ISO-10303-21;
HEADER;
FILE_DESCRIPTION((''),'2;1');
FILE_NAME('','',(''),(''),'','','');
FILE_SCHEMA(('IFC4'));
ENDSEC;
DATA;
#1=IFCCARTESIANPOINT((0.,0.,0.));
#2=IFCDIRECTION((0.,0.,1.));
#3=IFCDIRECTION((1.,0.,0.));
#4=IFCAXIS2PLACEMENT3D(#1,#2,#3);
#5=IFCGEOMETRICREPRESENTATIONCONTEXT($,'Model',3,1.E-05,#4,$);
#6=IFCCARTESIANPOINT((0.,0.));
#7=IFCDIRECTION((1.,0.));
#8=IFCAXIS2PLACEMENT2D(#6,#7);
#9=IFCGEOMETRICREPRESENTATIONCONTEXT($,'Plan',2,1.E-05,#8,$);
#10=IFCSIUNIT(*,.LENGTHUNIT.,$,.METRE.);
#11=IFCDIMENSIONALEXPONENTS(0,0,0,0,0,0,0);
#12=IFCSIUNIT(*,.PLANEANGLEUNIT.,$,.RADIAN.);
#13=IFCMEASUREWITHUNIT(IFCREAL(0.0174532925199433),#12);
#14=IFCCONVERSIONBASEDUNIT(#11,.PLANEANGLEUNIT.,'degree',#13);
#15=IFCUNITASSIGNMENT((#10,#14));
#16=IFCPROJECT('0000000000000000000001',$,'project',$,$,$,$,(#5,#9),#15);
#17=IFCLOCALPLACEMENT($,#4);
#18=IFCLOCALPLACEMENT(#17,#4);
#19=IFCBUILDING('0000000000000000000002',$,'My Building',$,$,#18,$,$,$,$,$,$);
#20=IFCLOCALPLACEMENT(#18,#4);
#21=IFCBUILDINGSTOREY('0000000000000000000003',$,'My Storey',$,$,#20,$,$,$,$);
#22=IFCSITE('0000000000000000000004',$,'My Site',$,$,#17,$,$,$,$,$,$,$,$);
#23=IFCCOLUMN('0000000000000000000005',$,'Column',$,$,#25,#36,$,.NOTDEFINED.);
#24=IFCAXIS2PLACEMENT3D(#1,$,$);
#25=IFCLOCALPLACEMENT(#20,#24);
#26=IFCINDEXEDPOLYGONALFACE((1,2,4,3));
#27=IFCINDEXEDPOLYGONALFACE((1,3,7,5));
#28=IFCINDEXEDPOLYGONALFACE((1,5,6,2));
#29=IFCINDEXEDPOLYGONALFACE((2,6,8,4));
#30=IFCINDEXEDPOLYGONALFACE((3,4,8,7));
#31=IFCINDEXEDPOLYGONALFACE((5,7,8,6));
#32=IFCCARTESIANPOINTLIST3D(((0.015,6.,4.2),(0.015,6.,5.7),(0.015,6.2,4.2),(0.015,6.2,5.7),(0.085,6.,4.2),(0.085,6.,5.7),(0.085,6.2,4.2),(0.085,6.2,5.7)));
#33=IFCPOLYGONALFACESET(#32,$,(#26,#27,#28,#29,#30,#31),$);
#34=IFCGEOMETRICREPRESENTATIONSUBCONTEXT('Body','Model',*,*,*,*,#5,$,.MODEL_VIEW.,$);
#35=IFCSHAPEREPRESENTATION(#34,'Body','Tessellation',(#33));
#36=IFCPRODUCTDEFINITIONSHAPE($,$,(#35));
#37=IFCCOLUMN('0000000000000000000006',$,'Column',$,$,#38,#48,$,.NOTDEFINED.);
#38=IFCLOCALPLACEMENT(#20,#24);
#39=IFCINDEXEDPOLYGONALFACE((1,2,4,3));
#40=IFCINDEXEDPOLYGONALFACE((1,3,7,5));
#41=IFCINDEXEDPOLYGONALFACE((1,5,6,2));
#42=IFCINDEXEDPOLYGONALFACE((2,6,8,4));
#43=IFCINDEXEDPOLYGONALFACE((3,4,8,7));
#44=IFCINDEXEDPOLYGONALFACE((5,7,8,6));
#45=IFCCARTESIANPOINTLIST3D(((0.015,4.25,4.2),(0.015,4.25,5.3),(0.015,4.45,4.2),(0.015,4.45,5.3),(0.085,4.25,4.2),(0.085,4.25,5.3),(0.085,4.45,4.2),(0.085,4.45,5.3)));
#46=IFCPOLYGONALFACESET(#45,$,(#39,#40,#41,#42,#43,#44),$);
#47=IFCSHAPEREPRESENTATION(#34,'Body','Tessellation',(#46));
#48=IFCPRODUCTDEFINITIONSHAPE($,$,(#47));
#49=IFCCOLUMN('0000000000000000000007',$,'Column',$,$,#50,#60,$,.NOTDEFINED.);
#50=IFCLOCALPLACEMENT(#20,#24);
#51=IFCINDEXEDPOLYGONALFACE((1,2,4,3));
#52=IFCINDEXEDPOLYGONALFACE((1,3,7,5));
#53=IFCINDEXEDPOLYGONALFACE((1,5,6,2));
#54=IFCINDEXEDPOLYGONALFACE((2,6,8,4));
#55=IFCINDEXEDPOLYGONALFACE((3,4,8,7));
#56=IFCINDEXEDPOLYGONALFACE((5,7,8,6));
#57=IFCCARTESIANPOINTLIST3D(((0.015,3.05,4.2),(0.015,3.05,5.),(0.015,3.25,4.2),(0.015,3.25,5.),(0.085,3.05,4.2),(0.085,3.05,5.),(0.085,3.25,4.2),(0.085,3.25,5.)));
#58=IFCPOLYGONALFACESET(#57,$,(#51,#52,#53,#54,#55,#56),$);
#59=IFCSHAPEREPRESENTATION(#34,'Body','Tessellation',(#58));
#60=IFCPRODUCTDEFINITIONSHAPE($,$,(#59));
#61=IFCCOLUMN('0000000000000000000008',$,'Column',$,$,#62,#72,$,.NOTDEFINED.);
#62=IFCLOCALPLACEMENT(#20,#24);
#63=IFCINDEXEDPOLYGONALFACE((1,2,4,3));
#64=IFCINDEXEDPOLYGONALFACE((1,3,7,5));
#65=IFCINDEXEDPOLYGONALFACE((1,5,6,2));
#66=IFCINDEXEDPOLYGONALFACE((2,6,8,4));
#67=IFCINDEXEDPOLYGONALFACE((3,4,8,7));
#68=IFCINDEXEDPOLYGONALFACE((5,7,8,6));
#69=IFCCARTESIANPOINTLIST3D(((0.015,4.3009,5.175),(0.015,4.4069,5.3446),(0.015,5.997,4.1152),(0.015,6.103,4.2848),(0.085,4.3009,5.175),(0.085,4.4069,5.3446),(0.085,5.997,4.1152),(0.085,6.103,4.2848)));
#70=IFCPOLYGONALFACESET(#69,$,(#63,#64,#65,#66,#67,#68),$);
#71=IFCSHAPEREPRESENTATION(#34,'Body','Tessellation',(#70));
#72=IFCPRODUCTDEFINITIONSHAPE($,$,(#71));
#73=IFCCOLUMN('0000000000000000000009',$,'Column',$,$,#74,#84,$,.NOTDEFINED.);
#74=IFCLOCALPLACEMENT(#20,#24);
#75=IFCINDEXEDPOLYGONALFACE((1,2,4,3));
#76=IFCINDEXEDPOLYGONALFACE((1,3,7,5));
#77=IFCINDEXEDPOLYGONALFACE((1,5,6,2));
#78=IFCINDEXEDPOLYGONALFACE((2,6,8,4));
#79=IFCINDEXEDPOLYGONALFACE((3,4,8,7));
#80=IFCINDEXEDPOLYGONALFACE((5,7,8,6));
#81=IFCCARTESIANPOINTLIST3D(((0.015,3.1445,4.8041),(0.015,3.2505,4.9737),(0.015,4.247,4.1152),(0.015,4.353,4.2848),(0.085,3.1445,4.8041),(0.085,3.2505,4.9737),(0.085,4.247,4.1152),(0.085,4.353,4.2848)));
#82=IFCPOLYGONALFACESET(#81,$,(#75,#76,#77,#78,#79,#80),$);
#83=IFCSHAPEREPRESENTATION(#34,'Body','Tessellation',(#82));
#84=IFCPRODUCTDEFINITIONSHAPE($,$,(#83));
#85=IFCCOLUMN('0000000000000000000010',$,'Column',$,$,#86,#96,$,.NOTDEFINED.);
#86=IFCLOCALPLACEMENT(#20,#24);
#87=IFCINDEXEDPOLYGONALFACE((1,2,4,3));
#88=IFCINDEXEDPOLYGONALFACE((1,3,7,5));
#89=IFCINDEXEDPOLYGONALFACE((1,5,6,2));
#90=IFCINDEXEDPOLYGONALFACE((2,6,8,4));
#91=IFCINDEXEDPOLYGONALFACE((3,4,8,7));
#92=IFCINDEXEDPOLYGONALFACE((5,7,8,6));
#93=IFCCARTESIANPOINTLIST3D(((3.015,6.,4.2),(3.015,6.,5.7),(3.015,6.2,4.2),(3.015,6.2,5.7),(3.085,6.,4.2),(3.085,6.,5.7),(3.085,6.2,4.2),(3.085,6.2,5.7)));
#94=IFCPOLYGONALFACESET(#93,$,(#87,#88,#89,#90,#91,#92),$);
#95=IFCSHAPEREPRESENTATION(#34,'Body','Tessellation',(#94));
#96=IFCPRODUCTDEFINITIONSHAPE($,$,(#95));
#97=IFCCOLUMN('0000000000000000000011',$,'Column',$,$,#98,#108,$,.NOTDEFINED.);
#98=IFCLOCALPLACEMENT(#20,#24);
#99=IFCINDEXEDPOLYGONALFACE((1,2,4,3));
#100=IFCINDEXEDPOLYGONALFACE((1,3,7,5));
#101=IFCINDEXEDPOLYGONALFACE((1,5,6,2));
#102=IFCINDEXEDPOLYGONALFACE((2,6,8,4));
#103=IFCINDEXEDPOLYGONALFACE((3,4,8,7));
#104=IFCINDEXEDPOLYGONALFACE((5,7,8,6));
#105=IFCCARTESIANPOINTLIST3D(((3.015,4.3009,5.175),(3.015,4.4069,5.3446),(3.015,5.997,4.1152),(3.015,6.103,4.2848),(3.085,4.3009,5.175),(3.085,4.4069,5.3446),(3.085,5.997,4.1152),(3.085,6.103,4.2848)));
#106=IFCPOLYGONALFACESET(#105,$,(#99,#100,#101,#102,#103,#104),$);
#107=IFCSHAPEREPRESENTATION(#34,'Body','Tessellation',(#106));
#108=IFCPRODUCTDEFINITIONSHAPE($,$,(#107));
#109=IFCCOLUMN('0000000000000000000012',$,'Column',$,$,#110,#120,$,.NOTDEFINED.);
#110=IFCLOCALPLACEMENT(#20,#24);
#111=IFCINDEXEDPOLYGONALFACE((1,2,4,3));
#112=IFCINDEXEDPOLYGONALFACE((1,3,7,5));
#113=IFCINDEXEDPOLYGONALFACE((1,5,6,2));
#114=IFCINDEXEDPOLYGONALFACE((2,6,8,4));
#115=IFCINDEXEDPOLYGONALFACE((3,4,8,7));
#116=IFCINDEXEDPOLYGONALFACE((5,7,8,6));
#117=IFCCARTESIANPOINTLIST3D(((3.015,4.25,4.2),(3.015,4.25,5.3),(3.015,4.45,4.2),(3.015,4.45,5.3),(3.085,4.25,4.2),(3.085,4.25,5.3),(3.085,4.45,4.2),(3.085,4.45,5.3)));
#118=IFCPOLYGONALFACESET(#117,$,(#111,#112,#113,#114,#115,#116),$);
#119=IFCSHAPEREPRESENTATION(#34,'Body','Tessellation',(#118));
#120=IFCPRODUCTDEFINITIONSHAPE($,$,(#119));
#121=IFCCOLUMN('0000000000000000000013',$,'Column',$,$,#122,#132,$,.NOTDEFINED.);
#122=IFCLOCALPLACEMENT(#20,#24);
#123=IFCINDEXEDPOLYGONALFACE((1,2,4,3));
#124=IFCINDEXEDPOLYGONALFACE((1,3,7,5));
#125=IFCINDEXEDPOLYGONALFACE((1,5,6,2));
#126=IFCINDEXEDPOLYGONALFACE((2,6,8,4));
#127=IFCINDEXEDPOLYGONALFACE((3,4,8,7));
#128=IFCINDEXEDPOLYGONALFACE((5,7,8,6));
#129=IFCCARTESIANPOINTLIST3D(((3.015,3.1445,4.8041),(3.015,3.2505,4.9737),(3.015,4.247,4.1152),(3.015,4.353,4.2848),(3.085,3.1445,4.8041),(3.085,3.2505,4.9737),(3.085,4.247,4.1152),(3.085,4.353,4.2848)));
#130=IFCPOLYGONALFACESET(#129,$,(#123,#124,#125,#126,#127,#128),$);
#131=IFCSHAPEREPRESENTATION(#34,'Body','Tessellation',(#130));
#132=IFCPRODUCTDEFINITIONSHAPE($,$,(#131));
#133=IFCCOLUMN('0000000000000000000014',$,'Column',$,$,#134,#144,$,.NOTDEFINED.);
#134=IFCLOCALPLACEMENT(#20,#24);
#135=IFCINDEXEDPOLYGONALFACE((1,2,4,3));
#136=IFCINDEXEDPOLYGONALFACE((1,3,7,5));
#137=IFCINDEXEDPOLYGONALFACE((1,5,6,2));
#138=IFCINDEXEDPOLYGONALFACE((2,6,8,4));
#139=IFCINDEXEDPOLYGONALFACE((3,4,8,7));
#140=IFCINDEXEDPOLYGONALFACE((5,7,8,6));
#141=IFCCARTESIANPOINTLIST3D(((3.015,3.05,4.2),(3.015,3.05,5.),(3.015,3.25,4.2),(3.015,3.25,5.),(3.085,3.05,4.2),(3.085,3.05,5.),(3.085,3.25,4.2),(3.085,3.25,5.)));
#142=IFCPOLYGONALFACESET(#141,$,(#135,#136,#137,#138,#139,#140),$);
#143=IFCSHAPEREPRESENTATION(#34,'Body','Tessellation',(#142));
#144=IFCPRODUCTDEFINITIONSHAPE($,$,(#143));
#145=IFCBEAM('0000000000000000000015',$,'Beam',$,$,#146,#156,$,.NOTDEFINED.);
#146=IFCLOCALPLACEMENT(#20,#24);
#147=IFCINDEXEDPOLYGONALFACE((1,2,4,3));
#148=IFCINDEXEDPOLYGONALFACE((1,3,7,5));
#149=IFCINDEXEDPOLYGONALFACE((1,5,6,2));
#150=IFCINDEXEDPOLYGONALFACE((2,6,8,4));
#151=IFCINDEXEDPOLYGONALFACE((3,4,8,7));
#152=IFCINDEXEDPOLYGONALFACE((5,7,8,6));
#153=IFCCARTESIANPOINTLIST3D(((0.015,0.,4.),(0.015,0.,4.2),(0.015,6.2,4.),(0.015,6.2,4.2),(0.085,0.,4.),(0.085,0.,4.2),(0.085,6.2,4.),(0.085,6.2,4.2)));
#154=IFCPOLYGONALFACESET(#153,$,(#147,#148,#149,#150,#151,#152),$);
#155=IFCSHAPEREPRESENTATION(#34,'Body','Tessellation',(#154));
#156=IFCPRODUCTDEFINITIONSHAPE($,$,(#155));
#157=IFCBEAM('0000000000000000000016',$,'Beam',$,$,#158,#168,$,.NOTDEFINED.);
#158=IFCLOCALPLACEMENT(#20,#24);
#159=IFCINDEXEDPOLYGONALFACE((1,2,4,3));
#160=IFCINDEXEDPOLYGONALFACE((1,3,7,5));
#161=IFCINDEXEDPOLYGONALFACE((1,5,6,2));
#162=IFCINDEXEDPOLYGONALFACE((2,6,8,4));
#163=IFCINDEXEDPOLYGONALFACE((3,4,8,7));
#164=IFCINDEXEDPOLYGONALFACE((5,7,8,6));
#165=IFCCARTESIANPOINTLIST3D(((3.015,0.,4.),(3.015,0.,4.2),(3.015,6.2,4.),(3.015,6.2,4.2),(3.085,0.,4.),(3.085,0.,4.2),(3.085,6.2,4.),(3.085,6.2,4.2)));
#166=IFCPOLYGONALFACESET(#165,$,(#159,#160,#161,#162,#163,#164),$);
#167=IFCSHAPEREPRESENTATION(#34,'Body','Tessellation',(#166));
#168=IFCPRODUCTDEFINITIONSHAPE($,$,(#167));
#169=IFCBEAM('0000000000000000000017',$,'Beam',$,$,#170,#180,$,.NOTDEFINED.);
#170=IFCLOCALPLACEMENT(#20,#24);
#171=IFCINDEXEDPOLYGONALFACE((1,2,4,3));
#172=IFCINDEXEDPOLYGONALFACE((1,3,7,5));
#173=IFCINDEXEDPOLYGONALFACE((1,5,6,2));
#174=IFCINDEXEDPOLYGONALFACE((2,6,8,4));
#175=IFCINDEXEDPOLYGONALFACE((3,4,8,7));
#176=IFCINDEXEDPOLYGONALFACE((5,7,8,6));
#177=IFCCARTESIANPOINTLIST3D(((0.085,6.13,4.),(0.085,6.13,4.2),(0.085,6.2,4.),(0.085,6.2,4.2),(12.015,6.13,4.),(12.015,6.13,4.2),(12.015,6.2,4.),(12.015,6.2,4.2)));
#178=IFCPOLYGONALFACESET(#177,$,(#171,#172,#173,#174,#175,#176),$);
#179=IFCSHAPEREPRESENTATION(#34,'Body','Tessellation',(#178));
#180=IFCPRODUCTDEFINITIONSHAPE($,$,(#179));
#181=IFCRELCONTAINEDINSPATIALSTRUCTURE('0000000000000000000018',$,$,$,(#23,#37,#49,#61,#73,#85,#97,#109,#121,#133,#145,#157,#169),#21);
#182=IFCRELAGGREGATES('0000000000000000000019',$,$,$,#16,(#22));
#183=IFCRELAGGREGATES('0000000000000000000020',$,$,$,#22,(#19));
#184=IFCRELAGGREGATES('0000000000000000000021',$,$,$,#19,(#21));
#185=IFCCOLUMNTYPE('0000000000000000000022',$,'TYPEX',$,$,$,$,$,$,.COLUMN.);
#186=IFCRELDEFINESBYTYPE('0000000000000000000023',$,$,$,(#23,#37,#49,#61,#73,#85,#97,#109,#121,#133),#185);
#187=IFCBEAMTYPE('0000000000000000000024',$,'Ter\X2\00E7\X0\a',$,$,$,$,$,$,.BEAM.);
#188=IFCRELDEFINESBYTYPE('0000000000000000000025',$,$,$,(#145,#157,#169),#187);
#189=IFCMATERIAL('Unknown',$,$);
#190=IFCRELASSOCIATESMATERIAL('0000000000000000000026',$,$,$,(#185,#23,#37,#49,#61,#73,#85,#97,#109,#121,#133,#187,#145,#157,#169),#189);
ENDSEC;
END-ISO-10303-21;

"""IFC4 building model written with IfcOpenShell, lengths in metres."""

from ifc_helpers import new_model, entity, si_unit, converted_unit, frame, origin_with_axes, origin_2d_with_axis, place, context, subcontext, project, spatial, rectangle, extrude, material, material_profile, profile_set, profile_usage, type_object, element, save


model = new_model("IFC4")

# Units and contexts
model_context = context("Model", 3, precision=1e-05, world=origin_with_axes())
plan_context = context("Plan", 2, precision=1e-05, world=origin_2d_with_axis())
body_context = subcontext(model_context, "Body", "Model", "MODEL_VIEW")
ifc_project = project(units=[si_unit("LENGTHUNIT", "METRE"), converted_unit("PLANEANGLEUNIT", "degree", entity("IfcReal", 0.0174532925199433), si_unit("PLANEANGLEUNIT", "RADIAN"), dimensions=[0, 0, 0, 0, 0, 0, 0])], contexts=[model_context, plan_context])

# Site, building, storey
site_placement = place(None, origin_with_axes())
site = spatial("IfcSite", under=ifc_project, at=site_placement, Name="My Site")
building_placement = place(site_placement, origin_with_axes())
building = spatial("IfcBuilding", under=site, at=building_placement, Name="My Building")
storey_placement = place(building_placement, origin_with_axes())
storey = spatial("IfcBuildingStorey", under=building, at=storey_placement, Name="My Storey")

# Columns
ifc_material_1 = material(Name="Unknown")
ifc_material_profile_1 = material_profile(ifc_material_1, rectangle(XDim=0.07, YDim=0.2))
ifc_profile_set_1 = profile_set([ifc_material_profile_1])
ifc_profile_usage_1 = profile_usage(ifc_profile_set_1, cardinal=2)
column_type = type_object("IfcColumnType", Name="TYPEX", PredefinedType="COLUMN", material=ifc_profile_set_1)
column_1_placement = place(storey_placement, frame((0.05, 6.2, 4.2), z_axis=(0.0, 0.0, 1.0), x_axis=(-1.0, 0.0, 0.0)))
element("IfcColumn", 1, at=column_1_placement, inside=storey, type_object=column_type, material=ifc_profile_usage_1, Name="Column", PredefinedType="NOTDEFINED", context=body_context, shape_type="SweptSolid", body=[
    extrude(rectangle(XDim=0.07, YDim=0.2), frame((0.0, 0.1, 0.0), z_axis=(0.0, 0.0, 1.0), x_axis=(1.0, 0.0, 0.0)), (0.0, 0.0, 1.0), 1.5),
])
ifc_profile_usage_2 = profile_usage(ifc_profile_set_1, cardinal=2)
column_2_placement = place(storey_placement, frame((0.05, 4.45, 4.2), z_axis=(0.0, 0.0, 1.0), x_axis=(-1.0, 0.0, 0.0)))
element("IfcColumn", 2, at=column_2_placement, inside=storey, type_object=column_type, material=ifc_profile_usage_2, Name="Column", PredefinedType="NOTDEFINED", context=body_context, shape_type="SweptSolid", body=[
    extrude(rectangle(XDim=0.07, YDim=0.2), frame((0.0, 0.1, 0.0), z_axis=(0.0, 0.0, 1.0), x_axis=(1.0, 0.0, 0.0)), (0.0, 0.0, 1.0), 1.1),
])
ifc_profile_usage_3 = profile_usage(ifc_profile_set_1, cardinal=2)
column_3_placement = place(storey_placement, frame((0.05, 3.25, 4.2), z_axis=(0.0, 0.0, 1.0), x_axis=(-1.0, 0.0, 0.0)))
element("IfcColumn", 3, at=column_3_placement, inside=storey, type_object=column_type, material=ifc_profile_usage_3, Name="Column", PredefinedType="NOTDEFINED", context=body_context, shape_type="SweptSolid", body=[
    extrude(rectangle(XDim=0.07, YDim=0.2), frame((0.0, 0.1, 0.0), z_axis=(0.0, 0.0, 1.0), x_axis=(1.0, 0.0, 0.0)), (0.0, 0.0, 1.0), 0.8),
])
ifc_profile_usage_4 = profile_usage(ifc_profile_set_1, cardinal=5)
column_4_placement = place(storey_placement, frame((0.05, 6.05, 4.2), z_axis=(0.0, -0.848048, 0.529919), x_axis=(-1.0, 0.0, 0.0)))
element("IfcColumn", 4, at=column_4_placement, inside=storey, type_object=column_type, material=ifc_profile_usage_4, Name="Column", PredefinedType="NOTDEFINED", context=body_context, shape_type="SweptSolid", body=[
    extrude(rectangle(XDim=0.07, YDim=0.2), origin_with_axes(), (0.0, 0.0, 1.0), 2.0),
])
ifc_profile_usage_5 = profile_usage(ifc_profile_set_1, cardinal=5)
column_5_placement = place(storey_placement, frame((0.05, 4.3, 4.2), z_axis=(0.0, -0.848048, 0.529919), x_axis=(-1.0, 0.0, 0.0)))
element("IfcColumn", 5, at=column_5_placement, inside=storey, type_object=column_type, material=ifc_profile_usage_5, Name="Column", PredefinedType="NOTDEFINED", context=body_context, shape_type="SweptSolid", body=[
    extrude(rectangle(XDim=0.07, YDim=0.2), origin_with_axes(), (0.0, 0.0, 1.0), 1.3),
])
ifc_profile_usage_6 = profile_usage(ifc_profile_set_1, cardinal=2)
column_6_placement = place(storey_placement, frame((3.05, 6.2, 4.2), z_axis=(0.0, 0.0, 1.0), x_axis=(-1.0, 0.0, 0.0)))
element("IfcColumn", 6, at=column_6_placement, inside=storey, type_object=column_type, material=ifc_profile_usage_6, Name="Column", PredefinedType="NOTDEFINED", context=body_context, shape_type="SweptSolid", body=[
    extrude(rectangle(XDim=0.07, YDim=0.2), frame((0.0, 0.1, 0.0), z_axis=(0.0, 0.0, 1.0), x_axis=(1.0, 0.0, 0.0)), (0.0, 0.0, 1.0), 1.5),
])
ifc_profile_usage_7 = profile_usage(ifc_profile_set_1, cardinal=5)
column_7_placement = place(storey_placement, frame((3.05, 6.05, 4.2), z_axis=(0.0, -0.848048, 0.529919), x_axis=(-1.0, 0.0, 0.0)))
element("IfcColumn", 7, at=column_7_placement, inside=storey, type_object=column_type, material=ifc_profile_usage_7, Name="Column", PredefinedType="NOTDEFINED", context=body_context, shape_type="SweptSolid", body=[
    extrude(rectangle(XDim=0.07, YDim=0.2), origin_with_axes(), (0.0, 0.0, 1.0), 2.0),
])
ifc_profile_usage_8 = profile_usage(ifc_profile_set_1, cardinal=2)
column_8_placement = place(storey_placement, frame((3.05, 4.45, 4.2), z_axis=(0.0, 0.0, 1.0), x_axis=(-1.0, 0.0, 0.0)))
element("IfcColumn", 8, at=column_8_placement, inside=storey, type_object=column_type, material=ifc_profile_usage_8, Name="Column", PredefinedType="NOTDEFINED", context=body_context, shape_type="SweptSolid", body=[
    extrude(rectangle(XDim=0.07, YDim=0.2), frame((0.0, 0.1, 0.0), z_axis=(0.0, 0.0, 1.0), x_axis=(1.0, 0.0, 0.0)), (0.0, 0.0, 1.0), 1.1),
])
ifc_profile_usage_9 = profile_usage(ifc_profile_set_1, cardinal=5)
column_9_placement = place(storey_placement, frame((3.05, 4.3, 4.2), z_axis=(0.0, -0.848048, 0.529919), x_axis=(-1.0, 0.0, 0.0)))
element("IfcColumn", 9, at=column_9_placement, inside=storey, type_object=column_type, material=ifc_profile_usage_9, Name="Column", PredefinedType="NOTDEFINED", context=body_context, shape_type="SweptSolid", body=[
    extrude(rectangle(XDim=0.07, YDim=0.2), origin_with_axes(), (0.0, 0.0, 1.0), 1.3),
])
ifc_profile_usage_10 = profile_usage(ifc_profile_set_1, cardinal=2)
column_10_placement = place(storey_placement, frame((3.05, 3.25, 4.2), z_axis=(0.0, 0.0, 1.0), x_axis=(-1.0, 0.0, 0.0)))
element("IfcColumn", 10, at=column_10_placement, inside=storey, type_object=column_type, material=ifc_profile_usage_10, Name="Column", PredefinedType="NOTDEFINED", context=body_context, shape_type="SweptSolid", body=[
    extrude(rectangle(XDim=0.07, YDim=0.2), frame((0.0, 0.1, 0.0), z_axis=(0.0, 0.0, 1.0), x_axis=(1.0, 0.0, 0.0)), (0.0, 0.0, 1.0), 0.8),
])

# Beams
ifc_material_profile_2 = material_profile(ifc_material_1, rectangle(XDim=0.07, YDim=0.2))
ifc_profile_set_2 = profile_set([ifc_material_profile_2])
ifc_profile_usage_11 = profile_usage(ifc_profile_set_2, cardinal=2)
beam_type_1 = type_object("IfcBeamType", Name="Terça", PredefinedType="BEAM", material=ifc_profile_set_2)
beam_1_placement = place(storey_placement, frame((0.05, 6.2, 4.0), z_axis=(0.0, -1.0, 0.0), x_axis=(1.0, 0.0, 0.0)))
element("IfcBeam", 11, at=beam_1_placement, inside=storey, type_object=beam_type_1, material=ifc_profile_usage_11, Name="Beam", PredefinedType="NOTDEFINED", context=body_context, shape_type="SweptSolid", body=[
    extrude(rectangle(XDim=0.07, YDim=0.2), frame((0.0, 0.1, 0.0), z_axis=(0.0, 0.0, 1.0), x_axis=(1.0, 0.0, 0.0)), (0.0, 0.0, 1.0), 6.2),
])
ifc_profile_usage_12 = profile_usage(ifc_profile_set_2, cardinal=2)
beam_2_placement = place(storey_placement, frame((3.05, 6.2, 4.0), z_axis=(0.0, -1.0, 0.0), x_axis=(1.0, 0.0, 0.0)))
element("IfcBeam", 12, at=beam_2_placement, inside=storey, type_object=beam_type_1, material=ifc_profile_usage_12, Name="Beam", PredefinedType="NOTDEFINED", context=body_context, shape_type="SweptSolid", body=[
    extrude(rectangle(XDim=0.07, YDim=0.2), frame((0.0, 0.1, 0.0), z_axis=(0.0, 0.0, 1.0), x_axis=(1.0, 0.0, 0.0)), (0.0, 0.0, 1.0), 6.2),
])
ifc_profile_usage_13 = profile_usage(ifc_profile_set_2, cardinal=2)
beam_3_placement = place(storey_placement, frame((0.085, 6.165, 4.0), z_axis=(1.0, 0.0, 0.0), x_axis=(0.0, 1.0, 0.0)))
element("IfcBeam", 13, at=beam_3_placement, inside=storey, type_object=beam_type_1, material=ifc_profile_usage_13, Name="Beam", PredefinedType="NOTDEFINED", context=body_context, shape_type="SweptSolid", body=[
    extrude(rectangle(XDim=0.07, YDim=0.2), frame((0.0, 0.1, 0.0), z_axis=(0.0, 0.0, 1.0), x_axis=(1.0, 0.0, 0.0)), (0.0, 0.0, 1.0), 11.93),
])

save(model, "model.ifc")
